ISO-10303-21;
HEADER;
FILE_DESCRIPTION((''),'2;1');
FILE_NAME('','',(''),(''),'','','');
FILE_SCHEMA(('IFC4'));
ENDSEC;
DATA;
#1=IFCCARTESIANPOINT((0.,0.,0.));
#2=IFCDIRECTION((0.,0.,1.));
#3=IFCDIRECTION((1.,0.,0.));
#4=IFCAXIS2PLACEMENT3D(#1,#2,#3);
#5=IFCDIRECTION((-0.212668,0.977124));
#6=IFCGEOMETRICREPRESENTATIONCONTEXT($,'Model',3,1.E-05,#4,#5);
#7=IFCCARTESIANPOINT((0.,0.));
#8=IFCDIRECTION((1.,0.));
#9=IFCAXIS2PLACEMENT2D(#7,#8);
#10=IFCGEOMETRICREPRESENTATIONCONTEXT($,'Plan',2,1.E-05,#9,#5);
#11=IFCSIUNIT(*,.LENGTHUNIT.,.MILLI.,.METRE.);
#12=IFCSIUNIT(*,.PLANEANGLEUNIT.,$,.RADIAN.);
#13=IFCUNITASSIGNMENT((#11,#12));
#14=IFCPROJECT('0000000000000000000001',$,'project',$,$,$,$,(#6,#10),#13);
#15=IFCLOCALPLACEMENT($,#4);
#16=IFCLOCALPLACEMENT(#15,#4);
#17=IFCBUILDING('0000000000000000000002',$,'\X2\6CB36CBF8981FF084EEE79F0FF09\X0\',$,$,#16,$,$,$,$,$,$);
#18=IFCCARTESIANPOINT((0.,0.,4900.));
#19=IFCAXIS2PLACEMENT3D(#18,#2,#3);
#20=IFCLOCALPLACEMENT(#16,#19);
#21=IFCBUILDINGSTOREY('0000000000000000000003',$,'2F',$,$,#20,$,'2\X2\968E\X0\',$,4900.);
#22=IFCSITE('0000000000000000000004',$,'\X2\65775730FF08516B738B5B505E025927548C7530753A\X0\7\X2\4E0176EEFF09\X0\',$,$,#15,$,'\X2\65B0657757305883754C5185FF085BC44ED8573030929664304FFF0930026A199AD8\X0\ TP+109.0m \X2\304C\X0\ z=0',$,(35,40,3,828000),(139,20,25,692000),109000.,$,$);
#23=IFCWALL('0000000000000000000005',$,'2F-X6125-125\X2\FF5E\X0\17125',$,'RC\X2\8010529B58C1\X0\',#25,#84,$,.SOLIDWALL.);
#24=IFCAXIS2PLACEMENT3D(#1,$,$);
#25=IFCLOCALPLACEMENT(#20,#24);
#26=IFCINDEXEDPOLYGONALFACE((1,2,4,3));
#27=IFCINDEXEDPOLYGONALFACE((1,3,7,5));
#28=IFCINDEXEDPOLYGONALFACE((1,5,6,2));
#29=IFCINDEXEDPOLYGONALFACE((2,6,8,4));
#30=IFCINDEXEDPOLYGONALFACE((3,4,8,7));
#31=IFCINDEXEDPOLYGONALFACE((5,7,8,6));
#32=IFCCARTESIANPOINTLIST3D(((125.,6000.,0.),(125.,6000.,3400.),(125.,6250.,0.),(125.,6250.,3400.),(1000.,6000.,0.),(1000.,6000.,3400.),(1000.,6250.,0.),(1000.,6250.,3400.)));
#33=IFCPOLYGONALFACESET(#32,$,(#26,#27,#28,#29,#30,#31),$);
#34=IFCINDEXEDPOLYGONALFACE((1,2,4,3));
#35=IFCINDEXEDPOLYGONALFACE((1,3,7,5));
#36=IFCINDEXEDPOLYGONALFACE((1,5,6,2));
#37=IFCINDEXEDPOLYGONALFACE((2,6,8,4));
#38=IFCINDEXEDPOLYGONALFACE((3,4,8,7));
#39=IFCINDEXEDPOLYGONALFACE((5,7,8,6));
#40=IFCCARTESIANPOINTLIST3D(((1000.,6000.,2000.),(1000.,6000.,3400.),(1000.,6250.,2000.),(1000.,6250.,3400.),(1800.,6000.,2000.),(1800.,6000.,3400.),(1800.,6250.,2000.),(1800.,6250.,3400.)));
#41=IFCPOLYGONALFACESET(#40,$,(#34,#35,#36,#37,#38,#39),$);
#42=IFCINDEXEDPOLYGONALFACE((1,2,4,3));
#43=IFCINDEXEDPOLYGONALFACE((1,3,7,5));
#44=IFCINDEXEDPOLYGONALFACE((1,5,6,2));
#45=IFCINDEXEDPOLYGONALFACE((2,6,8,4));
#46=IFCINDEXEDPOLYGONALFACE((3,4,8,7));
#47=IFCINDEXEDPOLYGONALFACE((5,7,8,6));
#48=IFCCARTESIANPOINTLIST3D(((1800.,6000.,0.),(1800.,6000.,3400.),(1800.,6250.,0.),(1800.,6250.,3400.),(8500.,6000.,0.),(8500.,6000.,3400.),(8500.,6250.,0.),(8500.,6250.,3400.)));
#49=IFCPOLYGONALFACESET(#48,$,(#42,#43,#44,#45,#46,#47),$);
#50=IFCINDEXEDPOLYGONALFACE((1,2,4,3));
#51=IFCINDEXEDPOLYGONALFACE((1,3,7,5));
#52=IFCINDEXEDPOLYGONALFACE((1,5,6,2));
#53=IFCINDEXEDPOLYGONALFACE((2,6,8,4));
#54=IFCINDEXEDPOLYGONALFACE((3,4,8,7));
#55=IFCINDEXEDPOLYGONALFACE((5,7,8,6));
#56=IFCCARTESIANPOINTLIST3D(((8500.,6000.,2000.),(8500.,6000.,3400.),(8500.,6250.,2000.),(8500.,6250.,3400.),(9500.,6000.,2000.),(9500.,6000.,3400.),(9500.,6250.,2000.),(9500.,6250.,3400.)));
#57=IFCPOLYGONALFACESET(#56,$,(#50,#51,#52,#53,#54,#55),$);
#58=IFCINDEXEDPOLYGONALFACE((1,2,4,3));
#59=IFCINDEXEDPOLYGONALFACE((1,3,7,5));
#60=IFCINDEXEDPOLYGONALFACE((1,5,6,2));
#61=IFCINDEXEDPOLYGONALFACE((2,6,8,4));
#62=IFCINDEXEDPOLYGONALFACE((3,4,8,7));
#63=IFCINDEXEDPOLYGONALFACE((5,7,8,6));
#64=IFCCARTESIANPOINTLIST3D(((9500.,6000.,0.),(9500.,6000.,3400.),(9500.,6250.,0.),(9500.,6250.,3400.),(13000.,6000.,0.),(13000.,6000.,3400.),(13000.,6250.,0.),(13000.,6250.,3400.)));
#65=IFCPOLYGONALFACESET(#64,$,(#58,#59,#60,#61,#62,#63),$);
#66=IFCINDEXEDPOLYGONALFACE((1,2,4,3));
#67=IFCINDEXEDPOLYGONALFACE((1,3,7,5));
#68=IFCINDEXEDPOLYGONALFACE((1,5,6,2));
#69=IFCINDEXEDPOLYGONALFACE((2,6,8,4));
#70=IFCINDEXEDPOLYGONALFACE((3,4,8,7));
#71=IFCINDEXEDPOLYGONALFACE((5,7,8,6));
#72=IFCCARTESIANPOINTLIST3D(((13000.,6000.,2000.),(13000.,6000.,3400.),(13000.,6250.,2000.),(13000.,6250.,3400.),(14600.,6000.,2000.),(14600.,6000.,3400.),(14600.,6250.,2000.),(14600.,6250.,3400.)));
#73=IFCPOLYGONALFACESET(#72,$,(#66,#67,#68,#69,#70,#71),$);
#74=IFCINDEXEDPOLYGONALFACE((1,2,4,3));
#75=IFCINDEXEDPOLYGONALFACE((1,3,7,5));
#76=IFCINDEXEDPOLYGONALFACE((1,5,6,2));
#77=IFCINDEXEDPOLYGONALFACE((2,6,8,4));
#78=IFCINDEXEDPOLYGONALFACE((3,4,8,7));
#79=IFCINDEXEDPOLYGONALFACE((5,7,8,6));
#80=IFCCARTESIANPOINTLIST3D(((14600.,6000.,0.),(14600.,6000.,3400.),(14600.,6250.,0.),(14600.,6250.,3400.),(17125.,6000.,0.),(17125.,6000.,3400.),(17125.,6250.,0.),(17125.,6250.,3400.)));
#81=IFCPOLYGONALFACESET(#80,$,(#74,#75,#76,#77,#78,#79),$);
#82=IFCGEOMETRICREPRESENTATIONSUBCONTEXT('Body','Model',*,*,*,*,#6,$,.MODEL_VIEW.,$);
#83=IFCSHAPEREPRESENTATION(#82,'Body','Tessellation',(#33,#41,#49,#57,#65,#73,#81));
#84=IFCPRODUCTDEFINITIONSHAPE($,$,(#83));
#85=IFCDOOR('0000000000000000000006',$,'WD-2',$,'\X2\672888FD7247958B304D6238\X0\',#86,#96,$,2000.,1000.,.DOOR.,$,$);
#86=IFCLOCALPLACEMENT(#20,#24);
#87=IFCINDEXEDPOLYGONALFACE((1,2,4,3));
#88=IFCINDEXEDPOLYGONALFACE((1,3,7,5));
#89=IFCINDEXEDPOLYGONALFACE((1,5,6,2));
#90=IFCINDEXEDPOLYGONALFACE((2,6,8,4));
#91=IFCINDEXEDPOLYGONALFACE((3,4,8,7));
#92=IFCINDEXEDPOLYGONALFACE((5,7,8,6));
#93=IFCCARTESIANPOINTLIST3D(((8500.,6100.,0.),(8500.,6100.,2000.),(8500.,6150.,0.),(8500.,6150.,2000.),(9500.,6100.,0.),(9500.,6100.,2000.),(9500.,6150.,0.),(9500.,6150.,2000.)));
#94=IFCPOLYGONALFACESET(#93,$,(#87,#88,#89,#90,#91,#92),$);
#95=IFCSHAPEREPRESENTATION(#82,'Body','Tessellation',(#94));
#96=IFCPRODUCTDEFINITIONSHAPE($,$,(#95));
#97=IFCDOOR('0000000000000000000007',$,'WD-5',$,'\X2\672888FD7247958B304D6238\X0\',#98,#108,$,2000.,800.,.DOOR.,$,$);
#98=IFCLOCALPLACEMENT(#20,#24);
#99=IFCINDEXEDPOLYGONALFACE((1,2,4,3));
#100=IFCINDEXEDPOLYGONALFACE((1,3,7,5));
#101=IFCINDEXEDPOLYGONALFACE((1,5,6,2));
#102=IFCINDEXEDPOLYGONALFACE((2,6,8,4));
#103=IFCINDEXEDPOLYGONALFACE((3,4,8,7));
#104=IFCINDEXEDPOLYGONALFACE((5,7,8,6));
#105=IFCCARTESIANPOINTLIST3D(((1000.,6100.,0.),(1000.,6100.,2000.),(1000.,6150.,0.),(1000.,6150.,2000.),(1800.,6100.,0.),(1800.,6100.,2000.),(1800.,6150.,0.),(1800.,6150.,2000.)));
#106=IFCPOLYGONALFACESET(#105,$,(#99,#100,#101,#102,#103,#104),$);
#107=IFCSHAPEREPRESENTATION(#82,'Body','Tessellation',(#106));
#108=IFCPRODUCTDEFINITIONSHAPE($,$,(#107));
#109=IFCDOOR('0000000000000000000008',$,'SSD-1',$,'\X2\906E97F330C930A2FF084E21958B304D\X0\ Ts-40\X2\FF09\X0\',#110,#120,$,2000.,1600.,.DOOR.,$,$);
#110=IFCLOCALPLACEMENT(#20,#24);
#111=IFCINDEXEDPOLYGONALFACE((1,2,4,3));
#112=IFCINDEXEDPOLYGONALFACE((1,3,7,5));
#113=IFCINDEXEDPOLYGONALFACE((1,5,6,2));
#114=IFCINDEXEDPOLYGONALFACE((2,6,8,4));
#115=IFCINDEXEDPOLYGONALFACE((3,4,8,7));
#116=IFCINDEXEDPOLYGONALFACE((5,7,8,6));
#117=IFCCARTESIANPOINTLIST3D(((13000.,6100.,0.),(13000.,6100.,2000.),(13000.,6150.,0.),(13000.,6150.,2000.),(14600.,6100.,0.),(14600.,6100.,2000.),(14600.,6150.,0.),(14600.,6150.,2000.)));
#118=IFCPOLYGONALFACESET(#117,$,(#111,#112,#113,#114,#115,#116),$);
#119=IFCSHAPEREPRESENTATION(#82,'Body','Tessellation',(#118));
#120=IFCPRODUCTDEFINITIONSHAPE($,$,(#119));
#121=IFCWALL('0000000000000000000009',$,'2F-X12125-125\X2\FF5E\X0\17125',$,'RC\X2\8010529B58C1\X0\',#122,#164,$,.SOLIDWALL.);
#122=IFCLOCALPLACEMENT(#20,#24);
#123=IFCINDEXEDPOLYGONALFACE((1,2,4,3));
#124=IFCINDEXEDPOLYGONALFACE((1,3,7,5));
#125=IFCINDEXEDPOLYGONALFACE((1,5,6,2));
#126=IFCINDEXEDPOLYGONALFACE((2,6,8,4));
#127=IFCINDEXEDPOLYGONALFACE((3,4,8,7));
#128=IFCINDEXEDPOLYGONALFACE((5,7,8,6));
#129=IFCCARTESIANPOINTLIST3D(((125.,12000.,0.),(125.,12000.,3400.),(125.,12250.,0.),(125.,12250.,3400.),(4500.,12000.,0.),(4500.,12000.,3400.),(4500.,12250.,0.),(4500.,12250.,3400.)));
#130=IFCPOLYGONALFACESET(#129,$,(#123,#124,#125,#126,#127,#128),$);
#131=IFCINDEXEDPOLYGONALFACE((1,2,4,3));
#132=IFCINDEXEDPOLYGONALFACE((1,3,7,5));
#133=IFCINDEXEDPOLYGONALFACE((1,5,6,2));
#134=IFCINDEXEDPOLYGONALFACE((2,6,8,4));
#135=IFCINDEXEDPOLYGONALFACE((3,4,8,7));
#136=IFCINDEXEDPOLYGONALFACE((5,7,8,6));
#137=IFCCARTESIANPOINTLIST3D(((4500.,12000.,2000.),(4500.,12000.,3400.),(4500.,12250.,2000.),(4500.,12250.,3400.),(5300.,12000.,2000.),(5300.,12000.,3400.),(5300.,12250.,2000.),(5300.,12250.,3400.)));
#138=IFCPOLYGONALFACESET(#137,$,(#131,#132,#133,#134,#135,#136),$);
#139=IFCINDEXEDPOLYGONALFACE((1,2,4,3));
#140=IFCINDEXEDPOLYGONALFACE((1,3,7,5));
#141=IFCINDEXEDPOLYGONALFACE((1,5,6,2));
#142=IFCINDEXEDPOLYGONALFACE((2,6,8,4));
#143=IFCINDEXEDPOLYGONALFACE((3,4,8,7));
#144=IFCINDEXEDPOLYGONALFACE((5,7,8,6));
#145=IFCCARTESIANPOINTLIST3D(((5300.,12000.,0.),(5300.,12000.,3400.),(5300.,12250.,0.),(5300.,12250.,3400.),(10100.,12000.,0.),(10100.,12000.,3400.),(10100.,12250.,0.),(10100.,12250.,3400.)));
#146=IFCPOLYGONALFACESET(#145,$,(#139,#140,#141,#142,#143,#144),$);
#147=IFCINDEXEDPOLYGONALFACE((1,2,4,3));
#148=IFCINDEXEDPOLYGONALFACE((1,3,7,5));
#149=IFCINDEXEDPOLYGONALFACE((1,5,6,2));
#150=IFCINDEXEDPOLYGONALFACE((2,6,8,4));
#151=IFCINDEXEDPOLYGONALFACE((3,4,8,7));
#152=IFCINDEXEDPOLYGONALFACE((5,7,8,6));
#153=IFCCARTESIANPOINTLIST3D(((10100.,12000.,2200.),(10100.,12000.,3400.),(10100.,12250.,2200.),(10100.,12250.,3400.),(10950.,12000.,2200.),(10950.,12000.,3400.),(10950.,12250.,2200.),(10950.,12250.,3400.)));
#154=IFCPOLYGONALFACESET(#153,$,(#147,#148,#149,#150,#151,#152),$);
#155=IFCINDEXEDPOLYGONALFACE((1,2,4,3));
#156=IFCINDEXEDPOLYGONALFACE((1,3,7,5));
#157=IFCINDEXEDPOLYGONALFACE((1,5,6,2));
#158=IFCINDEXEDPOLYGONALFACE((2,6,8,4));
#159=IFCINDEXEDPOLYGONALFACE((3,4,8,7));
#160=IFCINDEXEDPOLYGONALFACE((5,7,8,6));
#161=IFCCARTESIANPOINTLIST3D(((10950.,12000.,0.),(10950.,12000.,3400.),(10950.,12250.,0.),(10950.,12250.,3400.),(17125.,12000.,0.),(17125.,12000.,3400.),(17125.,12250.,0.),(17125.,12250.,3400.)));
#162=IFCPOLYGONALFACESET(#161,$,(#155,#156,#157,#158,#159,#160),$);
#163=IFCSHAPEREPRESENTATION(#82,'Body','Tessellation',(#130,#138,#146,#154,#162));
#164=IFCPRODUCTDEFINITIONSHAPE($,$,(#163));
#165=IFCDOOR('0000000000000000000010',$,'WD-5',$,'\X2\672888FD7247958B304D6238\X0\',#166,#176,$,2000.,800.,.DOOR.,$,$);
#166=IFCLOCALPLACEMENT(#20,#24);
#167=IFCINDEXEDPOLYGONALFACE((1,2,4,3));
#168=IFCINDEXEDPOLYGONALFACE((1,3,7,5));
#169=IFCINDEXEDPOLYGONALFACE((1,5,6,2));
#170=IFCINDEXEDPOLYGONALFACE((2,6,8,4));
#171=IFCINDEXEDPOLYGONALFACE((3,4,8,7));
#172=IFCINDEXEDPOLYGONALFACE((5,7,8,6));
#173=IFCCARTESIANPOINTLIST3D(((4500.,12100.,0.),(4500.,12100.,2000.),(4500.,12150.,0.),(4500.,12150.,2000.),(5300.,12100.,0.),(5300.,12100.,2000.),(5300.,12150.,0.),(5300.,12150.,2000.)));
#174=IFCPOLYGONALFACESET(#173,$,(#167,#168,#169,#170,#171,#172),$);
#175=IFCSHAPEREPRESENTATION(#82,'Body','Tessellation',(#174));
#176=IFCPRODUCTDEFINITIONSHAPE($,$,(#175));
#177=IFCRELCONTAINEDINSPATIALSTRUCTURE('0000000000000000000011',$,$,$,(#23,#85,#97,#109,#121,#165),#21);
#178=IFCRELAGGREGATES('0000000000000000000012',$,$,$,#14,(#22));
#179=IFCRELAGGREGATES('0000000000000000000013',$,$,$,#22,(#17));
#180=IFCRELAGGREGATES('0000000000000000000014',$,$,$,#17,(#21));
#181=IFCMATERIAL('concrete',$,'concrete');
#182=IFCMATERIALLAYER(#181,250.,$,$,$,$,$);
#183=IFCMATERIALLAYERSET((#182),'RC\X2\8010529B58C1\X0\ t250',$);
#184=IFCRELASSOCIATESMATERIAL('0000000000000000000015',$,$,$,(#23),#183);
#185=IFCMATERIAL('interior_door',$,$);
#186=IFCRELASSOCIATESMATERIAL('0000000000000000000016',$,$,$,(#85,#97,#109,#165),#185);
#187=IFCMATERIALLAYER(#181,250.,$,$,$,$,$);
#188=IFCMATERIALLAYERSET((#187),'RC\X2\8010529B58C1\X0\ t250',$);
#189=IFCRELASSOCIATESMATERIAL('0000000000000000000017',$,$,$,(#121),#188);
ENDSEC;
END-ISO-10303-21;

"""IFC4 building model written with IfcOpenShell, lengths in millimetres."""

from ifc_helpers import new_model, si_unit, direction, frame, frame_2d, origin, origin_with_axes, origin_2d_with_axis, place, context, subcontext, project, spatial, rectangle, extrude, material, layer, layer_set, layer_usage, element, fill, save


model = new_model("IFC4")

# Units and contexts
model_context = context("Model", 3, precision=1e-05, world=origin_with_axes(), true_north=direction((-0.212668, 0.977124)))
plan_context = context("Plan", 2, precision=1e-05, world=origin_2d_with_axis(), true_north=direction((-0.212668, 0.977124)))
body_context = subcontext(model_context, "Body", "Model", "MODEL_VIEW")
ifc_project = project(units=[si_unit("LENGTHUNIT", "METRE", prefix="MILLI"), si_unit("PLANEANGLEUNIT", "RADIAN")], contexts=[model_context, plan_context])

# Site, building, storey
site_placement = place(None, origin_with_axes())
site = spatial("IfcSite", under=ifc_project, at=site_placement, Name="敷地（八王子市大和田町7丁目）", LongName="新敷地境界内（寄付地を除く）。標高 TP+109.0m が z=0", RefLatitude=(35, 40, 3, 828000), RefLongitude=(139, 20, 25, 692000), RefElevation=109000.0)
building_placement = place(site_placement, origin_with_axes())
building = spatial("IfcBuilding", under=site, at=building_placement, Name="河沿要（仮称）")
storey_placement = place(building_placement, frame((0.0, 0.0, 4900.0), z_axis=(0.0, 0.0, 1.0), x_axis=(1.0, 0.0, 0.0)))
storey = spatial("IfcBuildingStorey", under=building, at=storey_placement, Name="2F", LongName="2階", Elevation=4900.0)

# Wall, openings, doors
ifc_material_1 = material(Name="concrete", Category="concrete")
ifc_material_2 = material(Name="interior_door")
ifc_layer_1 = layer(ifc_material_1, 250.0)
ifc_layer_set_1 = layer_set([ifc_layer_1], Name="RC耐力壁 t250")
ifc_layer_usage_1 = layer_usage(ifc_layer_set_1, "AXIS2", "POSITIVE", 0.0)
wall_1_placement = place(storey_placement, origin_with_axes())
wall_1 = element("IfcWall", 1, at=wall_1_placement, inside=storey, material=ifc_layer_usage_1, Name="2F-X6125-125～17125", ObjectType="RC耐力壁", PredefinedType="SOLIDWALL", context=body_context, shape_type="SweptSolid", body=[
    extrude(rectangle(XDim=875.0, YDim=250.0, at=frame_2d((562.5, 6125.0))), origin(), (0.0, 0.0, 1.0), 3400.0),
    extrude(rectangle(XDim=800.0, YDim=250.0, at=frame_2d((1400.0, 6125.0))), frame((0.0, 0.0, 2000.0)), (0.0, 0.0, 1.0), 1400.0),
    extrude(rectangle(XDim=6700.0, YDim=250.0, at=frame_2d((5150.0, 6125.0))), origin(), (0.0, 0.0, 1.0), 3400.0),
    extrude(rectangle(XDim=1000.0, YDim=250.0, at=frame_2d((9000.0, 6125.0))), frame((0.0, 0.0, 2000.0)), (0.0, 0.0, 1.0), 1400.0),
    extrude(rectangle(XDim=3500.0, YDim=250.0, at=frame_2d((11250.0, 6125.0))), origin(), (0.0, 0.0, 1.0), 3400.0),
    extrude(rectangle(XDim=1600.0, YDim=250.0, at=frame_2d((13800.0, 6125.0))), frame((0.0, 0.0, 2000.0)), (0.0, 0.0, 1.0), 1400.0),
    extrude(rectangle(XDim=2525.0, YDim=250.0, at=frame_2d((15862.5, 6125.0))), origin(), (0.0, 0.0, 1.0), 3400.0),
])
opening_1_placement = place(storey_placement, origin_with_axes())
opening_1 = element("IfcOpeningElement", 2, at=opening_1_placement, inside=storey, cuts=wall_1, PredefinedType="OPENING", context=body_context, shape_type="SweptSolid", body=[
    extrude(rectangle(XDim=1000.0, YDim=300.0, at=frame_2d((9000.0, 6125.0))), origin(), (0.0, 0.0, 1.0), 2000.0),
])
opening_2_placement = place(storey_placement, origin_with_axes())
opening_2 = element("IfcOpeningElement", 3, at=opening_2_placement, inside=storey, cuts=wall_1, PredefinedType="OPENING", context=body_context, shape_type="SweptSolid", body=[
    extrude(rectangle(XDim=800.0, YDim=300.0, at=frame_2d((1400.0, 6125.0))), origin(), (0.0, 0.0, 1.0), 2000.0),
])
opening_3_placement = place(storey_placement, origin_with_axes())
opening_3 = element("IfcOpeningElement", 4, at=opening_3_placement, inside=storey, cuts=wall_1, PredefinedType="OPENING", context=body_context, shape_type="SweptSolid", body=[
    extrude(rectangle(XDim=1600.0, YDim=300.0, at=frame_2d((13800.0, 6125.0))), origin(), (0.0, 0.0, 1.0), 2000.0),
])
door_1_placement = place(storey_placement, origin_with_axes())
door_1 = element("IfcDoor", 5, at=door_1_placement, inside=storey, material=ifc_material_2, Name="WD-2", ObjectType="木製片開き戸", OverallHeight=2000.0, OverallWidth=1000.0, PredefinedType="DOOR", context=body_context, shape_type="SweptSolid", body=[
    extrude(rectangle(XDim=1000.0, YDim=50.0, at=frame_2d((9000.0, 6125.0))), origin(), (0.0, 0.0, 1.0), 2000.0),
])
fill(opening_1, door_1)
door_2_placement = place(storey_placement, origin_with_axes())
door_2 = element("IfcDoor", 6, at=door_2_placement, inside=storey, material=ifc_material_2, Name="WD-5", ObjectType="木製片開き戸", OverallHeight=2000.0, OverallWidth=800.0, PredefinedType="DOOR", context=body_context, shape_type="SweptSolid", body=[
    extrude(rectangle(XDim=800.0, YDim=50.0, at=frame_2d((1400.0, 6125.0))), origin(), (0.0, 0.0, 1.0), 2000.0),
])
fill(opening_2, door_2)
door_3_placement = place(storey_placement, origin_with_axes())
door_3 = element("IfcDoor", 7, at=door_3_placement, inside=storey, material=ifc_material_2, Name="SSD-1", ObjectType="遮音ドア（両開き Ts-40）", OverallHeight=2000.0, OverallWidth=1600.0, PredefinedType="DOOR", context=body_context, shape_type="SweptSolid", body=[
    extrude(rectangle(XDim=1600.0, YDim=50.0, at=frame_2d((13800.0, 6125.0))), origin(), (0.0, 0.0, 1.0), 2000.0),
])
fill(opening_3, door_3)

# Wall, openings, door
ifc_layer_2 = layer(ifc_material_1, 250.0)
ifc_layer_set_2 = layer_set([ifc_layer_2], Name="RC耐力壁 t250")
ifc_layer_usage_2 = layer_usage(ifc_layer_set_2, "AXIS2", "POSITIVE", 0.0)
wall_2_placement = place(storey_placement, origin_with_axes())
wall_2 = element("IfcWall", 8, at=wall_2_placement, inside=storey, material=ifc_layer_usage_2, Name="2F-X12125-125～17125", ObjectType="RC耐力壁", PredefinedType="SOLIDWALL", context=body_context, shape_type="SweptSolid", body=[
    extrude(rectangle(XDim=4375.0, YDim=250.0, at=frame_2d((2312.5, 12125.0))), origin(), (0.0, 0.0, 1.0), 3400.0),
    extrude(rectangle(XDim=800.0, YDim=250.0, at=frame_2d((4900.0, 12125.0))), frame((0.0, 0.0, 2000.0)), (0.0, 0.0, 1.0), 1400.0),
    extrude(rectangle(XDim=4800.0, YDim=250.0, at=frame_2d((7700.0, 12125.0))), origin(), (0.0, 0.0, 1.0), 3400.0),
    extrude(rectangle(XDim=850.0, YDim=250.0, at=frame_2d((10525.0, 12125.0))), frame((0.0, 0.0, 2200.0)), (0.0, 0.0, 1.0), 1200.0),
    extrude(rectangle(XDim=6175.0, YDim=250.0, at=frame_2d((14037.5, 12125.0))), origin(), (0.0, 0.0, 1.0), 3400.0),
])
opening_4_placement = place(storey_placement, origin_with_axes())
element("IfcOpeningElement", 9, at=opening_4_placement, inside=storey, cuts=wall_2, PredefinedType="OPENING", context=body_context, shape_type="SweptSolid", body=[
    extrude(rectangle(XDim=850.0, YDim=300.0, at=frame_2d((10525.0, 12125.0))), origin(), (0.0, 0.0, 1.0), 2200.0),
])
opening_5_placement = place(storey_placement, origin_with_axes())
opening_5 = element("IfcOpeningElement", 10, at=opening_5_placement, inside=storey, cuts=wall_2, PredefinedType="OPENING", context=body_context, shape_type="SweptSolid", body=[
    extrude(rectangle(XDim=800.0, YDim=300.0, at=frame_2d((4900.0, 12125.0))), origin(), (0.0, 0.0, 1.0), 2000.0),
])
door_4_placement = place(storey_placement, origin_with_axes())
door_4 = element("IfcDoor", 11, at=door_4_placement, inside=storey, material=ifc_material_2, Name="WD-5", ObjectType="木製片開き戸", OverallHeight=2000.0, OverallWidth=800.0, PredefinedType="DOOR", context=body_context, shape_type="SweptSolid", body=[
    extrude(rectangle(XDim=800.0, YDim=50.0, at=frame_2d((4900.0, 12125.0))), origin(), (0.0, 0.0, 1.0), 2000.0),
])
fill(opening_5, door_4)

save(model, "model.ifc")
